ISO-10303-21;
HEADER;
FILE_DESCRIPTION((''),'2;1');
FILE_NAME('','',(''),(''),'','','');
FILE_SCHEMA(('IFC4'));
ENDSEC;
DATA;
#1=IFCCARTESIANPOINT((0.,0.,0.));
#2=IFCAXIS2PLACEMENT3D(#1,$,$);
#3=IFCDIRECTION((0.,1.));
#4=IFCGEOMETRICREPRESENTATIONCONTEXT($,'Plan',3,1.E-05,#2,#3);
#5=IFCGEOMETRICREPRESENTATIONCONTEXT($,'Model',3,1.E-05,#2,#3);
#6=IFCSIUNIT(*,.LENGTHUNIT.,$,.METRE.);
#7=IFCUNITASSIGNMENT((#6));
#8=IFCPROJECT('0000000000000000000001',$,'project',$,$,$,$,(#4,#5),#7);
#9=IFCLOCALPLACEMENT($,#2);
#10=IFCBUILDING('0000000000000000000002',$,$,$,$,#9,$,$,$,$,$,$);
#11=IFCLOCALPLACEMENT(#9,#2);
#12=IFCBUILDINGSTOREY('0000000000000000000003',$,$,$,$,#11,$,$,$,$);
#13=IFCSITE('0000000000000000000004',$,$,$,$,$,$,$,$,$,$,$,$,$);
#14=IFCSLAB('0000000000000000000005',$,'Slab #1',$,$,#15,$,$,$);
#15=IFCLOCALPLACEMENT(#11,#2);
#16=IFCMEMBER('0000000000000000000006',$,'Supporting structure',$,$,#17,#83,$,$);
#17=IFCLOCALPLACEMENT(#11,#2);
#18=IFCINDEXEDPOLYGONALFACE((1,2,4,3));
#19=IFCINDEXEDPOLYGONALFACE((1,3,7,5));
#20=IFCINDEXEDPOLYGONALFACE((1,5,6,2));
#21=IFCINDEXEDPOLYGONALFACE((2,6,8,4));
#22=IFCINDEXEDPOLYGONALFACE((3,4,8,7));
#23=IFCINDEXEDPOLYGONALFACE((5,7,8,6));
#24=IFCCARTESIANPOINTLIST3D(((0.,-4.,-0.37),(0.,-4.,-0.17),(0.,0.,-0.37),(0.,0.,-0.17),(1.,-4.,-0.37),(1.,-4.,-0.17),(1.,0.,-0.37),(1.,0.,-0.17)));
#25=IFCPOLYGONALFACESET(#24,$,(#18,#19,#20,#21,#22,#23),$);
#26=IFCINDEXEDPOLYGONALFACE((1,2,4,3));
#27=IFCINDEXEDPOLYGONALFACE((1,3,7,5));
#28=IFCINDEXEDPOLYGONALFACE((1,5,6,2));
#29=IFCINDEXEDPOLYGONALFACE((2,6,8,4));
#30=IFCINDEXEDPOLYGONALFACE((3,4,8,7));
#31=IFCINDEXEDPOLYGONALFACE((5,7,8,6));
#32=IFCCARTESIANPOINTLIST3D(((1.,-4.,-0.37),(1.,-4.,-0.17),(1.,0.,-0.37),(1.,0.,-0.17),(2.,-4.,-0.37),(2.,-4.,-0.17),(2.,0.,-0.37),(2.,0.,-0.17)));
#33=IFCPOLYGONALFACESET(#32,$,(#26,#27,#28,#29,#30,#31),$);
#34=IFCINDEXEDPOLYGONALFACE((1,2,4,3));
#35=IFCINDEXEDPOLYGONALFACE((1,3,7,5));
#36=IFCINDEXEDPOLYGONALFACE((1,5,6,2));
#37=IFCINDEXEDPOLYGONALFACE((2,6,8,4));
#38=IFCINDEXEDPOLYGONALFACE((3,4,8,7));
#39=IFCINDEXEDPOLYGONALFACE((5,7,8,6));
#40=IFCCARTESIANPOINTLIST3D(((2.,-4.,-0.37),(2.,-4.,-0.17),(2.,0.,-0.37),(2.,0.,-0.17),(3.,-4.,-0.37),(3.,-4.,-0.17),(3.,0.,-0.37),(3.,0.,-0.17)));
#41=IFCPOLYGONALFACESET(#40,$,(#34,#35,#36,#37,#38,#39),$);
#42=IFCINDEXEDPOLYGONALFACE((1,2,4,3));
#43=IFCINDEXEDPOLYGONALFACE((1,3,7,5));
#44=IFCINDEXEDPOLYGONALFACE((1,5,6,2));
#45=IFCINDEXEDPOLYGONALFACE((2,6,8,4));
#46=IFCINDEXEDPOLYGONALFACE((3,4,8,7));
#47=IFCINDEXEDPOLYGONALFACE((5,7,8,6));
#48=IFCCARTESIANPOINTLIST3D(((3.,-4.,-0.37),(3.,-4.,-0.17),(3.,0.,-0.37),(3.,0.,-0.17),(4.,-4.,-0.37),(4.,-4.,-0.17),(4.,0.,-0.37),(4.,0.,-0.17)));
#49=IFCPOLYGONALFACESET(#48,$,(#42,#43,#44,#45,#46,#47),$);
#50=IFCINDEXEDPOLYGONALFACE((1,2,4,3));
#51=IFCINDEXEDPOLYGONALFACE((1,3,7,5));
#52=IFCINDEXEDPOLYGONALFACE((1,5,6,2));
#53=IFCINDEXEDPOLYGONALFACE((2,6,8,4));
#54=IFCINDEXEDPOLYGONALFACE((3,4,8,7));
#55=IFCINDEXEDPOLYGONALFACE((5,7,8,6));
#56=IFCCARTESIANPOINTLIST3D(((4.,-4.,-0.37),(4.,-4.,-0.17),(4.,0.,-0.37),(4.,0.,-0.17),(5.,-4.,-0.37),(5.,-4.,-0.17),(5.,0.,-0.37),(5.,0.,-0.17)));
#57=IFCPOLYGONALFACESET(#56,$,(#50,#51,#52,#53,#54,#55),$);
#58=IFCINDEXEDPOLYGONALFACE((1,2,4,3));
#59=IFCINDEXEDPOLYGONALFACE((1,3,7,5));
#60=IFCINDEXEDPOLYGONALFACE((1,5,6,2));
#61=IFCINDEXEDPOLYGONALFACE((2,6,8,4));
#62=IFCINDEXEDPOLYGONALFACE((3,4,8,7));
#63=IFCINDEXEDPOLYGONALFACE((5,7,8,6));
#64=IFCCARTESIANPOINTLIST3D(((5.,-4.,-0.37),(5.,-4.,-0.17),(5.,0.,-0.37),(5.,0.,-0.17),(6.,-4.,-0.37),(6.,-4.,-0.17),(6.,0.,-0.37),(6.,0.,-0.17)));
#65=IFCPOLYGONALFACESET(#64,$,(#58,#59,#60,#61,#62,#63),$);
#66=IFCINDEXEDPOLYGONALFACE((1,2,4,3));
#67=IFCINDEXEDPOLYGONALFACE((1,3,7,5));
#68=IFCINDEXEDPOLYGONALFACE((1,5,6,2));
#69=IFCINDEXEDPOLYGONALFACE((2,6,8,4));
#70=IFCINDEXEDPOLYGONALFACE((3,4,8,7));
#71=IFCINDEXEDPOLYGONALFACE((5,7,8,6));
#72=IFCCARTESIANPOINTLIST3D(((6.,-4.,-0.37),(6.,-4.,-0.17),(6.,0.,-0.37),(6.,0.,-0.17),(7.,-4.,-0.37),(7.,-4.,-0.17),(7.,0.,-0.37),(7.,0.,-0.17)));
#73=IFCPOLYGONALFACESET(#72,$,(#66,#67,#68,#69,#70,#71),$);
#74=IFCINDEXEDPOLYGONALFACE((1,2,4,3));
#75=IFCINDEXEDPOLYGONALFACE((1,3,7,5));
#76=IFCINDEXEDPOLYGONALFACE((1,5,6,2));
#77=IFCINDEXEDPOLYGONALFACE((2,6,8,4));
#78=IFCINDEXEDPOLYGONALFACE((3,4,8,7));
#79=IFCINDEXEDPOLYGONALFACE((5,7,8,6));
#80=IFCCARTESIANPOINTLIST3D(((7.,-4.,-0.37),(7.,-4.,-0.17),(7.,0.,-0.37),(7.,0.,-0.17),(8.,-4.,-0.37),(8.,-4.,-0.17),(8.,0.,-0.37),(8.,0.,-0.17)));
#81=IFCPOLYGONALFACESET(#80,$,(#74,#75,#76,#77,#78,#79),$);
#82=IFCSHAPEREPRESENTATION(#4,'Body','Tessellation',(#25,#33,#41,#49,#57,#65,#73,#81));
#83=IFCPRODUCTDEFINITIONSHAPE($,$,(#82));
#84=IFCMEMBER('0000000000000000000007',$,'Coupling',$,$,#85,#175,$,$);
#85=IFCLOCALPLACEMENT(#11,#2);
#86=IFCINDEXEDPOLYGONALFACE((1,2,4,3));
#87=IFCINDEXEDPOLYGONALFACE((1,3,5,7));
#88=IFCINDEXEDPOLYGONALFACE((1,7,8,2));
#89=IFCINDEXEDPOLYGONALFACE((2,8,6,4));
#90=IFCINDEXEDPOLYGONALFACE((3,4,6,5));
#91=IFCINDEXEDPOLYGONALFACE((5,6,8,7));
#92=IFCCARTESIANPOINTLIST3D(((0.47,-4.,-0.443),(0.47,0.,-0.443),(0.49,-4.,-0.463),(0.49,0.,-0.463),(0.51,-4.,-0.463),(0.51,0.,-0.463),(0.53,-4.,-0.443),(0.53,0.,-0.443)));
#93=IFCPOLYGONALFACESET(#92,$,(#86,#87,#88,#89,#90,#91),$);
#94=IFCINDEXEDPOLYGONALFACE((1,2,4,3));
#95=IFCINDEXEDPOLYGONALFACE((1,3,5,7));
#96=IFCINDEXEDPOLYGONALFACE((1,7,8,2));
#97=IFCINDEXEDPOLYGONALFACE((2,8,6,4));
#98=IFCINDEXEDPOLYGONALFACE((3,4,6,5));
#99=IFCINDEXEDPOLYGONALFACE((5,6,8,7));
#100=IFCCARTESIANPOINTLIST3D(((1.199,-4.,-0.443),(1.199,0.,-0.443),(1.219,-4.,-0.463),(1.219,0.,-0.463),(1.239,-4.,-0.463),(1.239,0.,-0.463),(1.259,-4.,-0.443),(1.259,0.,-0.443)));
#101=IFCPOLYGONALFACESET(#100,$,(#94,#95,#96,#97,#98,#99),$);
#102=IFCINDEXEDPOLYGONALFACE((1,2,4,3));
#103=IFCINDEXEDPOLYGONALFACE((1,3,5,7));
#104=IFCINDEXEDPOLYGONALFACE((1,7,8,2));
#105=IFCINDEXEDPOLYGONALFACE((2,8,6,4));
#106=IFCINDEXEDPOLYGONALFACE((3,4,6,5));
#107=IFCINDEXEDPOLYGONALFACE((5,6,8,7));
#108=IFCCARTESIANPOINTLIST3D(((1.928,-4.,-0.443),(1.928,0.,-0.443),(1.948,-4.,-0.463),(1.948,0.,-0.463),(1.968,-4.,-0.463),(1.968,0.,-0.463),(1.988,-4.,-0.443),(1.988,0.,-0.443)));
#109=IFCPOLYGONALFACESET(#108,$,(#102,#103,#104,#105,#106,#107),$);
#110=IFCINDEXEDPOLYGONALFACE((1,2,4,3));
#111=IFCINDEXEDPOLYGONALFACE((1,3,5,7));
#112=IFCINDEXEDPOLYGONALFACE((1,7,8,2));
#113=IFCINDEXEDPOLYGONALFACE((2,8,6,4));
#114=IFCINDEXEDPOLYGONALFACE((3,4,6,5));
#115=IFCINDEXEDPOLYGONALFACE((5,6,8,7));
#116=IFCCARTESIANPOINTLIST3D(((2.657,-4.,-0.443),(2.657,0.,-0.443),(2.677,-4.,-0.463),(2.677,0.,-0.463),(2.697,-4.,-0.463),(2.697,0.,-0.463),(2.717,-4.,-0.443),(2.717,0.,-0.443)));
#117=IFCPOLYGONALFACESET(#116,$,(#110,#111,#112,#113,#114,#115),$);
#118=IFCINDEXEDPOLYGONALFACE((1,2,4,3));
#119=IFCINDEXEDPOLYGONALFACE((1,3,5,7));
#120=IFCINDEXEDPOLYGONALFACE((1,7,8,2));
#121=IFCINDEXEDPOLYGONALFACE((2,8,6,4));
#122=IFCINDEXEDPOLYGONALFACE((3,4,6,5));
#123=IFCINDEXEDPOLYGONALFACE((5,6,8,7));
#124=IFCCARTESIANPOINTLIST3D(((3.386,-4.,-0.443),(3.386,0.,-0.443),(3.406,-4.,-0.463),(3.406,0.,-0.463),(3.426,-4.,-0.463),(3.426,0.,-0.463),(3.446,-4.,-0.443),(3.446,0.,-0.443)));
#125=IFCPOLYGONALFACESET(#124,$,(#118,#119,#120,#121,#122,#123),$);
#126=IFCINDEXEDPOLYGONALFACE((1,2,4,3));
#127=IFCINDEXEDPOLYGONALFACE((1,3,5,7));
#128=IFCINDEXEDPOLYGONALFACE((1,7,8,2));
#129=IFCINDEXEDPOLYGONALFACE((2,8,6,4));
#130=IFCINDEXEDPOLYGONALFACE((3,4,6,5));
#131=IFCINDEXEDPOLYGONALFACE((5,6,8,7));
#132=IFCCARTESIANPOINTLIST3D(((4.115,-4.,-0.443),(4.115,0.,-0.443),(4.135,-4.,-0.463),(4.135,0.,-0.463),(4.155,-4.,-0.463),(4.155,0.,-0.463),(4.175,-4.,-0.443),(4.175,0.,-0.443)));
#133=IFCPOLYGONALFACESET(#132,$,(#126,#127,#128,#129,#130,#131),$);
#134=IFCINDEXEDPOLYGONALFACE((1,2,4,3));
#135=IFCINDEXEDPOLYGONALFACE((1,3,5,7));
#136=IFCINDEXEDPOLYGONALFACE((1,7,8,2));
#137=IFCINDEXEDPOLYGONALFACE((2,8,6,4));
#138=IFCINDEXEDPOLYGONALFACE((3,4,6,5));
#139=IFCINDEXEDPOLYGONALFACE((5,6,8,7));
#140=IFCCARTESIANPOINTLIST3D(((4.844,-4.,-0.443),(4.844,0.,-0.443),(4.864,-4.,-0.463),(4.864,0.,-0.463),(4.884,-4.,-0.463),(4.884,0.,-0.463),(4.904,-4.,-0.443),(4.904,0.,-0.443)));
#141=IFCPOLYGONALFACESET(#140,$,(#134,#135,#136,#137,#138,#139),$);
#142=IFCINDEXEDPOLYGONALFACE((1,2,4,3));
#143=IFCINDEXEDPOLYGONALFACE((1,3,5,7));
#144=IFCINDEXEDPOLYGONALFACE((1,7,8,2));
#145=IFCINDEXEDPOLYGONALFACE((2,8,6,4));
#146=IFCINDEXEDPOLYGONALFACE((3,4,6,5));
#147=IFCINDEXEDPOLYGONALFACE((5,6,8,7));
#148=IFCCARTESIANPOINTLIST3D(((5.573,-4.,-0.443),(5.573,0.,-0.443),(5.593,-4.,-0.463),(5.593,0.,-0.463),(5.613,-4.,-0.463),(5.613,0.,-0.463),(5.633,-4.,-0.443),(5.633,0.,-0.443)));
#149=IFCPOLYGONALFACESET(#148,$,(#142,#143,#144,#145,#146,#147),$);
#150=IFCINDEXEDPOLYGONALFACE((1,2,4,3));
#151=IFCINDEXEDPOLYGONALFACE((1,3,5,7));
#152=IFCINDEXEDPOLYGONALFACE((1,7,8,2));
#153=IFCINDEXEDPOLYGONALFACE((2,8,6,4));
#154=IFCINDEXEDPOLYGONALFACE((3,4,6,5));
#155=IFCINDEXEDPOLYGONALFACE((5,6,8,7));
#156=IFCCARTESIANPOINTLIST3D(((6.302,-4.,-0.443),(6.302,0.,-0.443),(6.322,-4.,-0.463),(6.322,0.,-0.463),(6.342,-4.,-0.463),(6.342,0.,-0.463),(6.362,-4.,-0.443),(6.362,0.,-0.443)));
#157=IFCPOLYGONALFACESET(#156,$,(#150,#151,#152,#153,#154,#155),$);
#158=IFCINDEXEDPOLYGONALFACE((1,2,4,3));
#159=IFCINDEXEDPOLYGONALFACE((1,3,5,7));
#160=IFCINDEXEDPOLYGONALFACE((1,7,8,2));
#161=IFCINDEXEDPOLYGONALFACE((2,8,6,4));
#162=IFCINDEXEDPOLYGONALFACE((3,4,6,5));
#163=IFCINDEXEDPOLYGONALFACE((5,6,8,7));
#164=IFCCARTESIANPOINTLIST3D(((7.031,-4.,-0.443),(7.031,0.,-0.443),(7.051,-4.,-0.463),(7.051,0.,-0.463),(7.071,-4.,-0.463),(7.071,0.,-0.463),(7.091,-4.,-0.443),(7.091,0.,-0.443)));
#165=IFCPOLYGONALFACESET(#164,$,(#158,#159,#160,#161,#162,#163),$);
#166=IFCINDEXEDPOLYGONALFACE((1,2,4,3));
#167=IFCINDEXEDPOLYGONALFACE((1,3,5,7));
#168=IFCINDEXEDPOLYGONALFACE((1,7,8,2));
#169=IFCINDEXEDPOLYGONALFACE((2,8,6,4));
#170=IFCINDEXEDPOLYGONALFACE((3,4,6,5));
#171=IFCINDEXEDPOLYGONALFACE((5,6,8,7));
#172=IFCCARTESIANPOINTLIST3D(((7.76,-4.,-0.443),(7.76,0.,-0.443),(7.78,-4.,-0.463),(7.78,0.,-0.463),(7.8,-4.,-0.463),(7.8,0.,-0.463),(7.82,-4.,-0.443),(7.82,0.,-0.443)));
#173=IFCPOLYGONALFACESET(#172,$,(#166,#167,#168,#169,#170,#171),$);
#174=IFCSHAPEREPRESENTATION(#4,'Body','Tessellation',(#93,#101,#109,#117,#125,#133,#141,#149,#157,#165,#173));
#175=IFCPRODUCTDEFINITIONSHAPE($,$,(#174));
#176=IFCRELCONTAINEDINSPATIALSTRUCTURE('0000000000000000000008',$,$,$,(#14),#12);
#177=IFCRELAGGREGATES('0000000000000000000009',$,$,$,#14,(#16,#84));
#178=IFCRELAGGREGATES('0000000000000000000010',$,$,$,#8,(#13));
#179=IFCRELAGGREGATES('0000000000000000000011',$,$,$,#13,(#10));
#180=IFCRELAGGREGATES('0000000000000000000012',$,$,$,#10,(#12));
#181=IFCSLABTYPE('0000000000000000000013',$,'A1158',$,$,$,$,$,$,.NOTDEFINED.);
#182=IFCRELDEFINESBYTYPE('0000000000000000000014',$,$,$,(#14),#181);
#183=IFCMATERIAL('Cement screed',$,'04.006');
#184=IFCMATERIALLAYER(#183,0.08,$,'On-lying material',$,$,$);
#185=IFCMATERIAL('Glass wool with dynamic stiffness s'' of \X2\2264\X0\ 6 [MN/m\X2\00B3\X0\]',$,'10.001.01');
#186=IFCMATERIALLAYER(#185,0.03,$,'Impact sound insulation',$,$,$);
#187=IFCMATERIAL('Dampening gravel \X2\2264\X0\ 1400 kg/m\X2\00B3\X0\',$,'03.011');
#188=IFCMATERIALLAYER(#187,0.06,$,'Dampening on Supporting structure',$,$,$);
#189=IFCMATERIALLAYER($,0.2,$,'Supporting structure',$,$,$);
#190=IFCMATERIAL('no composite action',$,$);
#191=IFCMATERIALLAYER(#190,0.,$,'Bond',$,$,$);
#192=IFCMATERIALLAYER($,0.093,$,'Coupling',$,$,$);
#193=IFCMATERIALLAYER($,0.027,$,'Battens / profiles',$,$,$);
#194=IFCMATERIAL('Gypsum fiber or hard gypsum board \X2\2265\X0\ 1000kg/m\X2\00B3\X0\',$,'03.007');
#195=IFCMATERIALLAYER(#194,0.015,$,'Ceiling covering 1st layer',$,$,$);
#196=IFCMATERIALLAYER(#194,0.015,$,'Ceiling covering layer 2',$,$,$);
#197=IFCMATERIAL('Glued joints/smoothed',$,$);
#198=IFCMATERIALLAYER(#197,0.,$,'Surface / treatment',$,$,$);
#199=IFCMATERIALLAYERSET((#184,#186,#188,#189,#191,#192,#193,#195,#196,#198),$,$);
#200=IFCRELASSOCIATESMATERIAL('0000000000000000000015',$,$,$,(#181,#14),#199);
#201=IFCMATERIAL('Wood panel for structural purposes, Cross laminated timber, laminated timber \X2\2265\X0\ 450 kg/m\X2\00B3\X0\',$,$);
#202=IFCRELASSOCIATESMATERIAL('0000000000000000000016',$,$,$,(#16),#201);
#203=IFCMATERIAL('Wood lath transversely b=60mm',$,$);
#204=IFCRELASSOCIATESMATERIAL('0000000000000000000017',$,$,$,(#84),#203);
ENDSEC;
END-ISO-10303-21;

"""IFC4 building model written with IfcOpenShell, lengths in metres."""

from ifc_helpers import new_model, si_unit, direction, frame, frame_2d, origin, place, context, project, spatial, polyline, rectangle, outline, extrude, material, layer, layer_set, type_object, element, aggregate, save


model = new_model("IFC4")

# Units and contexts
plan_context = context("Plan", 3, precision=1e-05, world=origin(), true_north=direction((0.0, 1.0)))
model_context = context("Model", 3, precision=1e-05, world=origin(), true_north=direction((0.0, 1.0)))
ifc_project = project(units=[si_unit("LENGTHUNIT", "METRE")], contexts=[plan_context, model_context])

# Site, building, storey
site = spatial("IfcSite", under=ifc_project)
building_placement = place(None, origin())
building = spatial("IfcBuilding", under=site, at=building_placement)
storey_placement = place(building_placement, origin())
storey = spatial("IfcBuildingStorey", under=building, at=storey_placement)

# Slab, members
ifc_material_1 = material(Name="Cement screed", Category="04.006")
ifc_layer_1 = layer(ifc_material_1, 0.08, Name="On-lying material")
ifc_material_2 = material(Name="Glass wool with dynamic stiffness s' of ≤ 6 [MN/m³]", Category="10.001.01")
ifc_layer_2 = layer(ifc_material_2, 0.03, Name="Impact sound insulation")
ifc_material_3 = material(Name="Dampening gravel ≤ 1400 kg/m³", Category="03.011")
ifc_layer_3 = layer(ifc_material_3, 0.06, Name="Dampening on Supporting structure")
ifc_layer_4 = layer(None, 0.2, Name="Supporting structure")
ifc_material_4 = material(Name="no composite action")
ifc_layer_5 = layer(ifc_material_4, 0.0, Name="Bond")
ifc_layer_6 = layer(None, 0.093, Name="Coupling")
ifc_layer_7 = layer(None, 0.027, Name="Battens / profiles")
ifc_material_5 = material(Name="Gypsum fiber or hard gypsum board ≥ 1000kg/m³", Category="03.007")
ifc_layer_8 = layer(ifc_material_5, 0.015, Name="Ceiling covering 1st layer")
ifc_layer_9 = layer(ifc_material_5, 0.015, Name="Ceiling covering layer 2")
ifc_material_6 = material(Name="Glued joints/smoothed")
ifc_layer_10 = layer(ifc_material_6, 0.0, Name="Surface / treatment")
ifc_layer_set = layer_set([ifc_layer_1, ifc_layer_2, ifc_layer_3, ifc_layer_4, ifc_layer_5, ifc_layer_6, ifc_layer_7, ifc_layer_8, ifc_layer_9, ifc_layer_10])
slab_type = type_object("IfcSlabType", Name="A1158", PredefinedType="NOTDEFINED", material=ifc_layer_set)
slab_placement = place(None, frame((0.0, 0.0, 0.0), z_axis=(0.0, 0.0, -1.0), x_axis=(1.0, 0.0, 0.0)))
slab = element("IfcSlab", 1, at=slab_placement, inside=storey, type_object=slab_type, material=ifc_layer_set, Name="Slab #1")
ifc_material_7 = material(Name="Wood panel for structural purposes, Cross laminated timber, laminated timber ≥ 450 kg/m³")
member_1_placement = place(slab_placement, origin())
member_1 = element("IfcMember", 2, at=member_1_placement, material=ifc_material_7, Name="Supporting structure", context=plan_context, shape_type="SweptSolid", body=[
    extrude(rectangle(XDim=1.0, YDim=0.2, at=frame_2d((0.5, 0.1), x_axis=(1.0, 0.0))), frame((0.0, 4.0, 0.17), z_axis=(0.0, -1.0, 0.0), x_axis=(1.0, 0.0, 0.0)), (0.0, 0.0, 1.0), 4.0),
    extrude(rectangle(XDim=1.0, YDim=0.2, at=frame_2d((0.5, 0.1), x_axis=(1.0, 0.0))), frame((1.0, 4.0, 0.17), z_axis=(0.0, -1.0, 0.0), x_axis=(1.0, 0.0, 0.0)), (0.0, 0.0, 1.0), 4.0),
    extrude(rectangle(XDim=1.0, YDim=0.2, at=frame_2d((0.5, 0.1), x_axis=(1.0, 0.0))), frame((2.0, 4.0, 0.17), z_axis=(0.0, -1.0, 0.0), x_axis=(1.0, 0.0, 0.0)), (0.0, 0.0, 1.0), 4.0),
    extrude(rectangle(XDim=1.0, YDim=0.2, at=frame_2d((0.5, 0.1), x_axis=(1.0, 0.0))), frame((3.0, 4.0, 0.17), z_axis=(0.0, -1.0, 0.0), x_axis=(1.0, 0.0, 0.0)), (0.0, 0.0, 1.0), 4.0),
    extrude(rectangle(XDim=1.0, YDim=0.2, at=frame_2d((0.5, 0.1), x_axis=(1.0, 0.0))), frame((4.0, 4.0, 0.17), z_axis=(0.0, -1.0, 0.0), x_axis=(1.0, 0.0, 0.0)), (0.0, 0.0, 1.0), 4.0),
    extrude(rectangle(XDim=1.0, YDim=0.2, at=frame_2d((0.5, 0.1), x_axis=(1.0, 0.0))), frame((5.0, 4.0, 0.17), z_axis=(0.0, -1.0, 0.0), x_axis=(1.0, 0.0, 0.0)), (0.0, 0.0, 1.0), 4.0),
    extrude(rectangle(XDim=1.0, YDim=0.2, at=frame_2d((0.5, 0.1), x_axis=(1.0, 0.0))), frame((6.0, 4.0, 0.17), z_axis=(0.0, -1.0, 0.0), x_axis=(1.0, 0.0, 0.0)), (0.0, 0.0, 1.0), 4.0),
    extrude(rectangle(XDim=1.0, YDim=0.2, at=frame_2d((0.5, 0.1), x_axis=(1.0, 0.0))), frame((7.0, 4.0, 0.17), z_axis=(0.0, -1.0, 0.0), x_axis=(1.0, 0.0, 0.0)), (0.0, 0.0, 1.0), 4.0),
])
ifc_material_8 = material(Name="Wood lath transversely b=60mm")
member_2_placement = place(slab_placement, origin())
member_2 = element("IfcMember", 3, at=member_2_placement, material=ifc_material_8, Name="Coupling", context=plan_context, shape_type="SweptSolid", body=[
    extrude(outline(polyline([(0.0, 0.0), (0.06, 0.0), (0.04, 0.02), (0.02, 0.02), (0.0, 0.0)])), frame((0.47, 4.0, 0.443), z_axis=(0.0, -1.0, 0.0), x_axis=(1.0, 0.0, 0.0)), (0.0, 0.0, 1.0), 4.0),
    extrude(outline(polyline([(0.0, 0.0), (0.06, 0.0), (0.04, 0.02), (0.02, 0.02), (0.0, 0.0)])), frame((1.199, 4.0, 0.443), z_axis=(0.0, -1.0, 0.0), x_axis=(1.0, 0.0, 0.0)), (0.0, 0.0, 1.0), 4.0),
    extrude(outline(polyline([(0.0, 0.0), (0.06, 0.0), (0.04, 0.02), (0.02, 0.02), (0.0, 0.0)])), frame((1.928, 4.0, 0.443), z_axis=(0.0, -1.0, 0.0), x_axis=(1.0, 0.0, 0.0)), (0.0, 0.0, 1.0), 4.0),
    extrude(outline(polyline([(0.0, 0.0), (0.06, 0.0), (0.04, 0.02), (0.02, 0.02), (0.0, 0.0)])), frame((2.657, 4.0, 0.443), z_axis=(0.0, -1.0, 0.0), x_axis=(1.0, 0.0, 0.0)), (0.0, 0.0, 1.0), 4.0),
    extrude(outline(polyline([(0.0, 0.0), (0.06, 0.0), (0.04, 0.02), (0.02, 0.02), (0.0, 0.0)])), frame((3.386, 4.0, 0.443), z_axis=(0.0, -1.0, 0.0), x_axis=(1.0, 0.0, 0.0)), (0.0, 0.0, 1.0), 4.0),
    extrude(outline(polyline([(0.0, 0.0), (0.06, 0.0), (0.04, 0.02), (0.02, 0.02), (0.0, 0.0)])), frame((4.115, 4.0, 0.443), z_axis=(0.0, -1.0, 0.0), x_axis=(1.0, 0.0, 0.0)), (0.0, 0.0, 1.0), 4.0),
    extrude(outline(polyline([(0.0, 0.0), (0.06, 0.0), (0.04, 0.02), (0.02, 0.02), (0.0, 0.0)])), frame((4.844, 4.0, 0.443), z_axis=(0.0, -1.0, 0.0), x_axis=(1.0, 0.0, 0.0)), (0.0, 0.0, 1.0), 4.0),
    extrude(outline(polyline([(0.0, 0.0), (0.06, 0.0), (0.04, 0.02), (0.02, 0.02), (0.0, 0.0)])), frame((5.573, 4.0, 0.443), z_axis=(0.0, -1.0, 0.0), x_axis=(1.0, 0.0, 0.0)), (0.0, 0.0, 1.0), 4.0),
    extrude(outline(polyline([(0.0, 0.0), (0.06, 0.0), (0.04, 0.02), (0.02, 0.02), (0.0, 0.0)])), frame((6.302, 4.0, 0.443), z_axis=(0.0, -1.0, 0.0), x_axis=(1.0, 0.0, 0.0)), (0.0, 0.0, 1.0), 4.0),
    extrude(outline(polyline([(0.0, 0.0), (0.06, 0.0), (0.04, 0.02), (0.02, 0.02), (0.0, 0.0)])), frame((7.031, 4.0, 0.443), z_axis=(0.0, -1.0, 0.0), x_axis=(1.0, 0.0, 0.0)), (0.0, 0.0, 1.0), 4.0),
    extrude(outline(polyline([(0.0, 0.0), (0.06, 0.0), (0.04, 0.02), (0.02, 0.02), (0.0, 0.0)])), frame((7.76, 4.0, 0.443), z_axis=(0.0, -1.0, 0.0), x_axis=(1.0, 0.0, 0.0)), (0.0, 0.0, 1.0), 4.0),
])
aggregate(slab, [member_1, member_2])

save(model, "model.ifc")
